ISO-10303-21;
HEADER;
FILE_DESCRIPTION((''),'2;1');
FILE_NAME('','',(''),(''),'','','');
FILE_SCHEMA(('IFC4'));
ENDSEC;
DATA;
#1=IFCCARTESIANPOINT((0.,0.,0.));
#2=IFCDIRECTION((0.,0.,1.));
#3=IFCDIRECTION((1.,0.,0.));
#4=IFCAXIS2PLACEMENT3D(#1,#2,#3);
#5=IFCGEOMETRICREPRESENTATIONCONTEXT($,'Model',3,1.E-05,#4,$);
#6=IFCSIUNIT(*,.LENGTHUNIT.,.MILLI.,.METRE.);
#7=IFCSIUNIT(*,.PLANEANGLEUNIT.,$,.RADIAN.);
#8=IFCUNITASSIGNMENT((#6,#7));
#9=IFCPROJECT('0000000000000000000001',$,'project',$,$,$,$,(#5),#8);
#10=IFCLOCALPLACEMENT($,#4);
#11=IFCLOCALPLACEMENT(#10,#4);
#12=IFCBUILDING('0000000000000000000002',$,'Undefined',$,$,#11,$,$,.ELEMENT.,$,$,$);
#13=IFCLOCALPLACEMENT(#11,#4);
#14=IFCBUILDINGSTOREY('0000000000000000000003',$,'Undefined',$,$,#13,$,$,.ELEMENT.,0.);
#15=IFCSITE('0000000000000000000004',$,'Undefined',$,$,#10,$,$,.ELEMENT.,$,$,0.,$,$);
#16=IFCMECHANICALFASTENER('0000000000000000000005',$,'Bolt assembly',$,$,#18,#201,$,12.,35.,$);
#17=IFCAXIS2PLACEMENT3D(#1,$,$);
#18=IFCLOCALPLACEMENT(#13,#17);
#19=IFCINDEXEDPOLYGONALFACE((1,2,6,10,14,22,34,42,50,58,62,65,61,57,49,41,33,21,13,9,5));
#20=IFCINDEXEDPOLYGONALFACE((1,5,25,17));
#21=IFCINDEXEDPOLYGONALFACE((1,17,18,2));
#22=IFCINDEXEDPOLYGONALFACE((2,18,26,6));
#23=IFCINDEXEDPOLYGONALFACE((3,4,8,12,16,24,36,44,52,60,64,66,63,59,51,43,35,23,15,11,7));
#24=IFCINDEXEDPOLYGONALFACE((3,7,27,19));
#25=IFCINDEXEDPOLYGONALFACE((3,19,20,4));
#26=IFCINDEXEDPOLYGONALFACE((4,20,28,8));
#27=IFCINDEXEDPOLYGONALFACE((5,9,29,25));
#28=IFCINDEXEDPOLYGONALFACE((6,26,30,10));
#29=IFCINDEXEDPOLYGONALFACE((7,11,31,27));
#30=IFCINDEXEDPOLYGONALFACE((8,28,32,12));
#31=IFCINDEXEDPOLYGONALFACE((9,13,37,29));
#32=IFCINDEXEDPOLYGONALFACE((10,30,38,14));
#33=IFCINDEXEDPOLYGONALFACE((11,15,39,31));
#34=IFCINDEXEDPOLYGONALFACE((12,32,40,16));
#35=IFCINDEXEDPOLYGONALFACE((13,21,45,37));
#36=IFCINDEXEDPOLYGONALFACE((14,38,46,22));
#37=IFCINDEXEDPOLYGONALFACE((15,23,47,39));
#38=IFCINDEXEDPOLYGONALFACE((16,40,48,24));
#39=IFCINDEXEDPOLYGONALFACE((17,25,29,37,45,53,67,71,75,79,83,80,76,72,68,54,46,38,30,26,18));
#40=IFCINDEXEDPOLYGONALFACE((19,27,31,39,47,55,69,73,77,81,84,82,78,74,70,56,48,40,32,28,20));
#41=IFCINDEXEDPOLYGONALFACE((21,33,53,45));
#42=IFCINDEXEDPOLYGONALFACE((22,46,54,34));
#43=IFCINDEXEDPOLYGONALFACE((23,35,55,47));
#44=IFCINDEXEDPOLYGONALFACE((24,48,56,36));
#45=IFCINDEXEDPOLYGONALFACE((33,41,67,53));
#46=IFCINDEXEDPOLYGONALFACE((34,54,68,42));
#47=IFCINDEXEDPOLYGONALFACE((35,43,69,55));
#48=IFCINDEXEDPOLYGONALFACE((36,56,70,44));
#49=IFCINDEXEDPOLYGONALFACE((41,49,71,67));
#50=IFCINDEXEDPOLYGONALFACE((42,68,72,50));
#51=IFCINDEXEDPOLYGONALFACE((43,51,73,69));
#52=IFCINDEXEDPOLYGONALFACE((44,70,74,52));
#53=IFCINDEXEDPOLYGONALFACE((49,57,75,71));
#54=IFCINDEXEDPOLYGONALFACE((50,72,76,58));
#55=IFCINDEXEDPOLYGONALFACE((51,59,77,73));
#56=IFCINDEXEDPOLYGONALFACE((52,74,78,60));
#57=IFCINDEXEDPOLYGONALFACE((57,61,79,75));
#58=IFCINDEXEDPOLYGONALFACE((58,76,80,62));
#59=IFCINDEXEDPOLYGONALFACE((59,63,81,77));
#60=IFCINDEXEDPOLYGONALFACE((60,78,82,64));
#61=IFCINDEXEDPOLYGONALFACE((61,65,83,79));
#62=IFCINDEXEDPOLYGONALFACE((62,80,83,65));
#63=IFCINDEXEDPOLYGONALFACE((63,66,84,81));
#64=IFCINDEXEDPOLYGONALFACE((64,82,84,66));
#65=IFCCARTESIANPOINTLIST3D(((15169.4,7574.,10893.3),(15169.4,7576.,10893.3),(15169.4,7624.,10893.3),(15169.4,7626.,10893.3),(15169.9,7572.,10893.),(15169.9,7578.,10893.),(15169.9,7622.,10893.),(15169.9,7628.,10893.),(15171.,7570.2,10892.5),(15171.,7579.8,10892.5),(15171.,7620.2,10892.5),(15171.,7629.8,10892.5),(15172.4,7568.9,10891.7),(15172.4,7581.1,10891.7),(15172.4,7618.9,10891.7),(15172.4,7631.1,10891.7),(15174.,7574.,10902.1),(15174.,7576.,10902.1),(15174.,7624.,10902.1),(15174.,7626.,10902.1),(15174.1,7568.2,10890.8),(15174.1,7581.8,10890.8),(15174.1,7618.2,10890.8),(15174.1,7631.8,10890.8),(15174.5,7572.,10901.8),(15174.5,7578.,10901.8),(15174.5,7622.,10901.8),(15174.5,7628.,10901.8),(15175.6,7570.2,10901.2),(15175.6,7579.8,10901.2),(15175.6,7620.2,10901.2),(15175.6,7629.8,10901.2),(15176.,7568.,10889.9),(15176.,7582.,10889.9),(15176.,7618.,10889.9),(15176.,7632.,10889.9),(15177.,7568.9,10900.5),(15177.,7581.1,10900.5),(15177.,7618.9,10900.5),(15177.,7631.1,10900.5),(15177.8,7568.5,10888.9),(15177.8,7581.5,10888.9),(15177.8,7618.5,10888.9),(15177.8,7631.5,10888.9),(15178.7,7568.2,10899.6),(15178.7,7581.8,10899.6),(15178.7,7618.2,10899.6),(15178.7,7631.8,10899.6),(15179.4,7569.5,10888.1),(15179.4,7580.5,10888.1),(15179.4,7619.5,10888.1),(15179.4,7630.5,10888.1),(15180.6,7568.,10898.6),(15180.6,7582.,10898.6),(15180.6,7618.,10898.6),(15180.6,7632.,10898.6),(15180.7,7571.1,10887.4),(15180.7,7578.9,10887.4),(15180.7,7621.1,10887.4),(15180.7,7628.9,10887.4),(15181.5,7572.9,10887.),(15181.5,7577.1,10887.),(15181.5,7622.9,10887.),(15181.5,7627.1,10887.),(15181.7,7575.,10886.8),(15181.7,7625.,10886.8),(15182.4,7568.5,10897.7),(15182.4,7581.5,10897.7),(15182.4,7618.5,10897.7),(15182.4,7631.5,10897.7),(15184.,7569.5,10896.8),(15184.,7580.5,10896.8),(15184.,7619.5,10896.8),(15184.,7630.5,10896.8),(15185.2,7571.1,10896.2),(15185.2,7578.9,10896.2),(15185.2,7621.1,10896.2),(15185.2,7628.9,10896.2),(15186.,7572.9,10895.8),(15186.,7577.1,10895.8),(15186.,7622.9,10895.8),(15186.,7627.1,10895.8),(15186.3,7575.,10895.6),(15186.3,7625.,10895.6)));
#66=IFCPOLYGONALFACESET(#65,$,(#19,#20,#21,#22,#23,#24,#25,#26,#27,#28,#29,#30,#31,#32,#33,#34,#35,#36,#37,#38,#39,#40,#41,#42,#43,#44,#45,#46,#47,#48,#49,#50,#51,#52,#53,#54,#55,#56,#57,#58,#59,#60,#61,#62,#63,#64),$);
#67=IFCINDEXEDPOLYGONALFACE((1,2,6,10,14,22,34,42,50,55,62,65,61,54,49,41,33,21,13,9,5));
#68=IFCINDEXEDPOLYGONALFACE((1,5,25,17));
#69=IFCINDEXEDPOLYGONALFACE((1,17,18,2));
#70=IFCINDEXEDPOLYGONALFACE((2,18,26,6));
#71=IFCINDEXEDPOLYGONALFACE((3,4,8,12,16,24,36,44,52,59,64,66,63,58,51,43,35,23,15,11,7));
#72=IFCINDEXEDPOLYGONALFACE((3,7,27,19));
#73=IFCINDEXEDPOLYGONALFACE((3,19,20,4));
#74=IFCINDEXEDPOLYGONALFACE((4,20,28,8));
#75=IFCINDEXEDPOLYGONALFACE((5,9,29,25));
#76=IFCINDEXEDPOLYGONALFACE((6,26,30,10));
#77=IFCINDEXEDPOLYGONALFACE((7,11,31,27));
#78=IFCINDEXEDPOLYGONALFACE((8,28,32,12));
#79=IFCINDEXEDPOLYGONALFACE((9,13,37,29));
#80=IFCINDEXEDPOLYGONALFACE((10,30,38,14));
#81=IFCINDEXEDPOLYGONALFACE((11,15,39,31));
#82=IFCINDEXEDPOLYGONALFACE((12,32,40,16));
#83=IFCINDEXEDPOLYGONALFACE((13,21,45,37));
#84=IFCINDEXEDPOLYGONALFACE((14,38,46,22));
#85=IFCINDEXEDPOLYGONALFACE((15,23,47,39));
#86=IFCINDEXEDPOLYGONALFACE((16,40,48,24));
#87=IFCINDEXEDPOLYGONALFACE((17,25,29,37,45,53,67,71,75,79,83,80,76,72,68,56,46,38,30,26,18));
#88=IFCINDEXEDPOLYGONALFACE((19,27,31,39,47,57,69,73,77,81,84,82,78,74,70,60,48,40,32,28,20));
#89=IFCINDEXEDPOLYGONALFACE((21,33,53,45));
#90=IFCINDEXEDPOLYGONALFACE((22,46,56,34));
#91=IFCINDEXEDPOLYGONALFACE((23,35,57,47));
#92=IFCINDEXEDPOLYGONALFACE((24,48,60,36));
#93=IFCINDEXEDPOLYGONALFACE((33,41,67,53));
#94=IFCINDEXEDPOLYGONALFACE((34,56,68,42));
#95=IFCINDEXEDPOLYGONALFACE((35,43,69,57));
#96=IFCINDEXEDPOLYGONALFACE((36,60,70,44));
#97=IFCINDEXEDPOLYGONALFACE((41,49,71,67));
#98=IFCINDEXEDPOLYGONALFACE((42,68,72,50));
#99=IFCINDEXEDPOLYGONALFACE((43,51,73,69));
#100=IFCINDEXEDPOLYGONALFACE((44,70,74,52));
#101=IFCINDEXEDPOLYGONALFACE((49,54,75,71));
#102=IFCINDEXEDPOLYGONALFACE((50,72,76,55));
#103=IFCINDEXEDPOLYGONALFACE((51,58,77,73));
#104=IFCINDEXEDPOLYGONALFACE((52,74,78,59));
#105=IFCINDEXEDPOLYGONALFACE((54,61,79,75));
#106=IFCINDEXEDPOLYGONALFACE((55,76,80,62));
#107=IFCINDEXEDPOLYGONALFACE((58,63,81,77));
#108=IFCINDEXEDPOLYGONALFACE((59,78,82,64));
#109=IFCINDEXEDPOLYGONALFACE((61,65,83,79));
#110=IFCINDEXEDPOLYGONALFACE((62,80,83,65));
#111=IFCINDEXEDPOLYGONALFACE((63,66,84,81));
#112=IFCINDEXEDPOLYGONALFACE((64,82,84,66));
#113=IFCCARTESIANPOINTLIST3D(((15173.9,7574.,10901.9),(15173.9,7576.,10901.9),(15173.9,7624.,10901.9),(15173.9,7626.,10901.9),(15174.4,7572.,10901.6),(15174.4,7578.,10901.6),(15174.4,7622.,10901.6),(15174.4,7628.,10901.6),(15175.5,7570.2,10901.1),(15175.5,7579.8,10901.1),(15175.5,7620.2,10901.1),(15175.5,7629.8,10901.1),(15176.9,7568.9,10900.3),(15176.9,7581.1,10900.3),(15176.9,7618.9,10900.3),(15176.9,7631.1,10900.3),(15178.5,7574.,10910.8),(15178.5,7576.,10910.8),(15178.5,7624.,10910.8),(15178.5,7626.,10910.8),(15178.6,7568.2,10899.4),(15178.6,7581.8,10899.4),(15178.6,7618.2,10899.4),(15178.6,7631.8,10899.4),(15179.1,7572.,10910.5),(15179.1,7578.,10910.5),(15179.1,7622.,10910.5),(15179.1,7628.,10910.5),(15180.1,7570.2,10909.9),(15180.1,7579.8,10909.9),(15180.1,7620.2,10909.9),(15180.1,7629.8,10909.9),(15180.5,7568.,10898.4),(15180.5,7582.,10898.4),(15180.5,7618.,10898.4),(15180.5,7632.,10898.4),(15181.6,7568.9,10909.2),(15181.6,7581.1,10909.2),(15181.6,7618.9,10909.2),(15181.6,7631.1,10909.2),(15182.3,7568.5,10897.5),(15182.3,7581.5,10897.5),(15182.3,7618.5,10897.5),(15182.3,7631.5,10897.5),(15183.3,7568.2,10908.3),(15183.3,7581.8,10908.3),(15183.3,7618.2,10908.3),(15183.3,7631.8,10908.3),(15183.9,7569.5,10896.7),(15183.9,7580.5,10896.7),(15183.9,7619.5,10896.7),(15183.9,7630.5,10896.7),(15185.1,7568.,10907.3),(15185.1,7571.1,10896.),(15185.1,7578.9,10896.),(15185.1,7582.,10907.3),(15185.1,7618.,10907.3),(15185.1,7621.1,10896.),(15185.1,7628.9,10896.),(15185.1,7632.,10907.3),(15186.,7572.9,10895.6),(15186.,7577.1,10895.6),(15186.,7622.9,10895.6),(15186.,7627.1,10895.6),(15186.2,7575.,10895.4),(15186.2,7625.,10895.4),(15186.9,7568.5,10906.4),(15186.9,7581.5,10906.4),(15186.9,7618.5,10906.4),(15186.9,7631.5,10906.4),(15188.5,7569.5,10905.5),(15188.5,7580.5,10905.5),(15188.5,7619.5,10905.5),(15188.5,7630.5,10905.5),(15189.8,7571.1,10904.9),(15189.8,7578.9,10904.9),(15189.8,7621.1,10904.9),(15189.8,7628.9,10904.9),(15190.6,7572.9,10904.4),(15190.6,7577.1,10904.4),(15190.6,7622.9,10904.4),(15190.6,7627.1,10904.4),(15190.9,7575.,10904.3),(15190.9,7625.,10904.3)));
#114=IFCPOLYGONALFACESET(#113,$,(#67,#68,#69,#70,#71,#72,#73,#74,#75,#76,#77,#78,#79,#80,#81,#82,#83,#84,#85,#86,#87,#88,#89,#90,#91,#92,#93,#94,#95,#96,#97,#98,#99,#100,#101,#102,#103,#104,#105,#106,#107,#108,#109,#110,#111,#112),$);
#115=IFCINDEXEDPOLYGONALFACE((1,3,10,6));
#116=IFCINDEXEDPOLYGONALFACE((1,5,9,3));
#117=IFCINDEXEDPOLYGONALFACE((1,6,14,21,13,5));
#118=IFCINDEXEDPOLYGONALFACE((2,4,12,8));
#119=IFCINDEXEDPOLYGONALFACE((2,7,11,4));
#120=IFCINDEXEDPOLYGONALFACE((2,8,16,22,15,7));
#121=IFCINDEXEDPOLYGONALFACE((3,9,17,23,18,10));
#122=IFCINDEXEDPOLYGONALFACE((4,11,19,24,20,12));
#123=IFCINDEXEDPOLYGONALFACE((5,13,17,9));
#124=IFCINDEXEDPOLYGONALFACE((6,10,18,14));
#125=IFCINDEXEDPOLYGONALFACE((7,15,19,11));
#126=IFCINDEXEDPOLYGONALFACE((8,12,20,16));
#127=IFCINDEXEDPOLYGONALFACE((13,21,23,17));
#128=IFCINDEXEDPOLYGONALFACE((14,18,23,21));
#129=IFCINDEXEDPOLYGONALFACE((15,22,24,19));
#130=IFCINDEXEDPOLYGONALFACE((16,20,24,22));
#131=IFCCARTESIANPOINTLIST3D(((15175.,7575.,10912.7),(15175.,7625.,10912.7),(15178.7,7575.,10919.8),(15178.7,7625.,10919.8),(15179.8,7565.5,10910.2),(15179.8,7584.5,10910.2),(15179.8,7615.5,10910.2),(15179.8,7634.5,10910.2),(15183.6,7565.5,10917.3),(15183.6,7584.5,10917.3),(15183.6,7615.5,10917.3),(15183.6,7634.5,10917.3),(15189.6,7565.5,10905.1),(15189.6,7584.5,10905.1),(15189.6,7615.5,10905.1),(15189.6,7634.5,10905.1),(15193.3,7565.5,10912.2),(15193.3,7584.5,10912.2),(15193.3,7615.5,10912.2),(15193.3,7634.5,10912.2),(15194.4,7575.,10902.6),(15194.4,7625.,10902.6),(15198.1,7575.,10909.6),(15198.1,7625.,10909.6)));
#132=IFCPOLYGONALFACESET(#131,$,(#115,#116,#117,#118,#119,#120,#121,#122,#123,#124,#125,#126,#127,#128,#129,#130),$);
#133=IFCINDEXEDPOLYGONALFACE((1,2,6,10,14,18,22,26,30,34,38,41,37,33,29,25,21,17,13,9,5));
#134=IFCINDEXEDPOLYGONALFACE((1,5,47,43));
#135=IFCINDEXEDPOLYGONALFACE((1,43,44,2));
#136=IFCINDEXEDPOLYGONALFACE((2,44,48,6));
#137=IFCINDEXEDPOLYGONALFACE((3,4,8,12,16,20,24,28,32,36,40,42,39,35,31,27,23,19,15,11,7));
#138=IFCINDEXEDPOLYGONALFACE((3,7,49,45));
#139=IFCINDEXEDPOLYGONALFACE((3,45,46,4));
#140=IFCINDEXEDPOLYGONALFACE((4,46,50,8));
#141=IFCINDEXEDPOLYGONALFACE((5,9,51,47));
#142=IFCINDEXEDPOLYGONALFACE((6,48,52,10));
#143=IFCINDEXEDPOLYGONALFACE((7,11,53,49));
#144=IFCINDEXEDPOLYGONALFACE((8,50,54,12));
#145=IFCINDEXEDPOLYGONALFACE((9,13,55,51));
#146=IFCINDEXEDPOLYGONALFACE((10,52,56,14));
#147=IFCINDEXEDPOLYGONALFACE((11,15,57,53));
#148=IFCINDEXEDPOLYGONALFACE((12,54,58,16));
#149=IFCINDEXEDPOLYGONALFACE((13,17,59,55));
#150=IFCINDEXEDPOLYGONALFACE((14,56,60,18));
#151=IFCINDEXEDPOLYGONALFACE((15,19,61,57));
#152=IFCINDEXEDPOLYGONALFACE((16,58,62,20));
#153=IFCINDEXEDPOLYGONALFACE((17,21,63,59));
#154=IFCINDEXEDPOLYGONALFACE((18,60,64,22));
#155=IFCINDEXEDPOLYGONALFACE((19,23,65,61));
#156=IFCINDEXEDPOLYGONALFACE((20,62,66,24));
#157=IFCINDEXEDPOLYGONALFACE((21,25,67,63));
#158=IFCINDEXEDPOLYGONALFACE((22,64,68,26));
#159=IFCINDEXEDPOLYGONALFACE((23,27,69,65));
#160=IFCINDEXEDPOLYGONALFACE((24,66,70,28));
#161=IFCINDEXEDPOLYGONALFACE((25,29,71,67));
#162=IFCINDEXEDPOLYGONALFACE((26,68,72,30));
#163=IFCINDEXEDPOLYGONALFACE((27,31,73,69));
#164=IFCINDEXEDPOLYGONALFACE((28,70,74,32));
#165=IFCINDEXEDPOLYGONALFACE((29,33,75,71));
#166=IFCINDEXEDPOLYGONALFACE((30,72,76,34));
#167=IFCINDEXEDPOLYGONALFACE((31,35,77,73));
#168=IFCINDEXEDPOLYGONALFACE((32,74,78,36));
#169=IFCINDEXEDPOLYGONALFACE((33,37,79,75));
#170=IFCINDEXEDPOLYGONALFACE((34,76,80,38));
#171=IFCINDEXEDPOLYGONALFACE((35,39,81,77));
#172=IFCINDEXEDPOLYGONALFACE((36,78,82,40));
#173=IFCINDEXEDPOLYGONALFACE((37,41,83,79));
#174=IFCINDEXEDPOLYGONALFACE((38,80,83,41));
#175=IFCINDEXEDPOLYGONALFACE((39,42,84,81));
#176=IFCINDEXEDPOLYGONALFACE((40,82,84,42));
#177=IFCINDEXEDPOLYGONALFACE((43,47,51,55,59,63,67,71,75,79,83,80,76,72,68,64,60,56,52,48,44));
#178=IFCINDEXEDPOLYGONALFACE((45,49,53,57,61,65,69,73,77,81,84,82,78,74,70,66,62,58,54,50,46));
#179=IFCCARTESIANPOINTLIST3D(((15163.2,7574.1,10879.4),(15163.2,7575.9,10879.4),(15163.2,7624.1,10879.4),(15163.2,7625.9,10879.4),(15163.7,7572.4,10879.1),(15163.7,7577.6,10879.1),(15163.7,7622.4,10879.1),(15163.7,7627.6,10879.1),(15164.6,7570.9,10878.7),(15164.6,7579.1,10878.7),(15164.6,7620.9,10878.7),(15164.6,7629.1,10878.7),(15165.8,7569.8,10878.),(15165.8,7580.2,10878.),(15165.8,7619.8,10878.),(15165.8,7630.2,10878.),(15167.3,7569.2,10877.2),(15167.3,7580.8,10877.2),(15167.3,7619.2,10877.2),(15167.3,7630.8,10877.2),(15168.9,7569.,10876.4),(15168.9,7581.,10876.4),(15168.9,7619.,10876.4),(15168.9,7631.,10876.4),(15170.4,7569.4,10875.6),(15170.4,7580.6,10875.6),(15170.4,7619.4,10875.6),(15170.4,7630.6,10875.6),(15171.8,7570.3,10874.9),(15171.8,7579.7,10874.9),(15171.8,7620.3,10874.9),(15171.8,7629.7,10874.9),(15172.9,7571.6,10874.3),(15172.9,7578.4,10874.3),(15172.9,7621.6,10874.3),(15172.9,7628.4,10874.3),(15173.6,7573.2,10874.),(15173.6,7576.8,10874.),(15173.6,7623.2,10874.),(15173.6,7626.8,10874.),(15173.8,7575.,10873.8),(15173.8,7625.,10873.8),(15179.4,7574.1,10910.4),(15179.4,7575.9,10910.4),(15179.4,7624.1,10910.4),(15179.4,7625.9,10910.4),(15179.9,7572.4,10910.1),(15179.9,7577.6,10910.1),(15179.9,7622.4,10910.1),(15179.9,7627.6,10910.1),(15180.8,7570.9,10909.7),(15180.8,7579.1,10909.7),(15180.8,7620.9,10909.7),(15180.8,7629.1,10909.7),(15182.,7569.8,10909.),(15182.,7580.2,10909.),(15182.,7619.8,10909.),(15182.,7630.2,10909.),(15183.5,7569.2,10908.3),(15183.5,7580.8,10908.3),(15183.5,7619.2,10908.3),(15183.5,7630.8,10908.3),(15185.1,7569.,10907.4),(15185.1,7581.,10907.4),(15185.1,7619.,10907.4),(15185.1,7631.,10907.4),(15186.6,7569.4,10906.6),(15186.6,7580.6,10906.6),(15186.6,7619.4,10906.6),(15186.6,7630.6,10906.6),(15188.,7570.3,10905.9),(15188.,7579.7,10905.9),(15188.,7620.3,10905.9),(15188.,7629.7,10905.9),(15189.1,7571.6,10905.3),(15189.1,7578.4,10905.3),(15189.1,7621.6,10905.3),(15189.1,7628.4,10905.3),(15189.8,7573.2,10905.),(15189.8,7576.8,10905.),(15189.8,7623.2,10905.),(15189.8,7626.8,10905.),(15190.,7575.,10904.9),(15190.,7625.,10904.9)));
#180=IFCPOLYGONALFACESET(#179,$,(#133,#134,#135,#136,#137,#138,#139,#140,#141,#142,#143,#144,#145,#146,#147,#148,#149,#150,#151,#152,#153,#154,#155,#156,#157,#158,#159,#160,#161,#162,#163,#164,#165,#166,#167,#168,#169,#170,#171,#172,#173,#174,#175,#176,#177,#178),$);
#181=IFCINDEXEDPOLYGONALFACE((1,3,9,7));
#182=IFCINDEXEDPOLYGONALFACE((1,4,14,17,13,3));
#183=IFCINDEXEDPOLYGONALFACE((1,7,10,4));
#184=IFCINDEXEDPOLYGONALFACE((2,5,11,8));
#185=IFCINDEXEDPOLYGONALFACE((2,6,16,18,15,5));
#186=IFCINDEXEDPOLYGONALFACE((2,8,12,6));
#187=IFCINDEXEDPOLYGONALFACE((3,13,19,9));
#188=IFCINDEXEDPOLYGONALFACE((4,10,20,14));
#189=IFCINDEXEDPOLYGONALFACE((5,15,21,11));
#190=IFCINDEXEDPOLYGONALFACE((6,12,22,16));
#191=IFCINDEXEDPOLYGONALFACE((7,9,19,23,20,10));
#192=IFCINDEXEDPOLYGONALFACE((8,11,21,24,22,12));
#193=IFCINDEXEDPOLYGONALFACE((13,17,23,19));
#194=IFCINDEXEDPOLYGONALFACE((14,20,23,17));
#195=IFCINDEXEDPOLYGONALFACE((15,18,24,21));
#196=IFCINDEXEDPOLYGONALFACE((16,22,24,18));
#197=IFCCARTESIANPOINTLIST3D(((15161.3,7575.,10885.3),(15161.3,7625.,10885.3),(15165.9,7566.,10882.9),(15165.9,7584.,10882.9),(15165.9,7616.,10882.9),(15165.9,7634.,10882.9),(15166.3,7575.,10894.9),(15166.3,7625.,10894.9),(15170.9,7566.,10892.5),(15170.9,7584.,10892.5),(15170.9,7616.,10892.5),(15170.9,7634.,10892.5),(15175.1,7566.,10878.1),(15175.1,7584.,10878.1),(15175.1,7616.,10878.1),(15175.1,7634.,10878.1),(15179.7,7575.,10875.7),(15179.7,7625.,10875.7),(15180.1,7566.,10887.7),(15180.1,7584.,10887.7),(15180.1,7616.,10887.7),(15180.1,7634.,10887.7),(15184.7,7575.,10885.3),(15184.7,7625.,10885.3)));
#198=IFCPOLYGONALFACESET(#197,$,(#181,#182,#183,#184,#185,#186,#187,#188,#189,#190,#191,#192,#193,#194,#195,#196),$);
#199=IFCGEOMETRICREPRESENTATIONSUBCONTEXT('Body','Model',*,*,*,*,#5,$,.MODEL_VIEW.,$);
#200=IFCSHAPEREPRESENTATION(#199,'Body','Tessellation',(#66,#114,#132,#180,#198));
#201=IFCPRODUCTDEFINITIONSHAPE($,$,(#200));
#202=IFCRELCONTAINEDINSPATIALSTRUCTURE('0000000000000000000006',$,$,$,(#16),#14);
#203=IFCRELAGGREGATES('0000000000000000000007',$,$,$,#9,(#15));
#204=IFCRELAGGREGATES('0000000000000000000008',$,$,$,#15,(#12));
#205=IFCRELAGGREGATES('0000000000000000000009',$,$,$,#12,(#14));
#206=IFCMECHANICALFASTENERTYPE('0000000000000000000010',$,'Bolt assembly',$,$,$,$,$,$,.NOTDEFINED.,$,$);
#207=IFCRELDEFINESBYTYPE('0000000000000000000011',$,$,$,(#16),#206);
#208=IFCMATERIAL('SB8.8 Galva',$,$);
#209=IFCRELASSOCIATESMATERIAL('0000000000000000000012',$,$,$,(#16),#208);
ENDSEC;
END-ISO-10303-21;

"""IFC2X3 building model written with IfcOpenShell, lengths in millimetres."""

from ifc_helpers import new_model, si_unit, frame, origin_with_axes, origin_2d_with_axis, place, context, subcontext, project, spatial, polyline, circle, outline, extrude, source, transform, mapped, material, type_object, element, save


model = new_model("IFC2X3")

# Units and contexts
model_context = context("Model", 3, precision=1e-05, world=origin_with_axes())
body_context = subcontext(model_context, "Body", "Model", "MODEL_VIEW")
ifc_project = project(units=[si_unit("LENGTHUNIT", "METRE", prefix="MILLI"), si_unit("PLANEANGLEUNIT", "RADIAN")], contexts=[model_context])

# Site, building, storey
site_placement = place(None, origin_with_axes())
site = spatial("IfcSite", under=ifc_project, at=site_placement, Name="Undefined", CompositionType="ELEMENT", RefElevation=0.0)
building_placement = place(site_placement, origin_with_axes())
building = spatial("IfcBuilding", under=site, at=building_placement, Name="Undefined", CompositionType="ELEMENT")
storey_placement = place(building_placement, origin_with_axes())
storey = spatial("IfcBuildingStorey", under=building, at=storey_placement, Name="Undefined", CompositionType="ELEMENT", Elevation=0.0)

# Mechanical fastener
ifc_material_1 = material(Name="SB8.8 Galva")
mechanical_fastener_type = type_object("IfcMechanicalFastenerType", Name="Bolt assembly")
shared_shape_1 = source(origin_with_axes(), body_context, "Body", "SweptSolid", [
    extrude(circle(Radius=7.0, at=origin_2d_with_axis()), frame((0.0, -0.1, 0.0), z_axis=(0.0, 1.0, 0.0), x_axis=(1.0, 0.0, 0.0)), (0.0, 0.0, 1.0), 9.9),
    extrude(circle(Radius=7.0, at=origin_2d_with_axis()), frame((0.0, -9.9, 0.0), z_axis=(0.0, 1.0, 0.0), x_axis=(1.0, 0.0, 0.0)), (0.0, 0.0, 1.0), 10.0),
    extrude(outline(polyline([(11.0, 0.0), (5.5, 9.5), (-5.5, 9.5), (-11.0, 0.0), (-5.5, -9.5), (5.5, -9.5), (11.0, 0.0)])), frame((0.0, -18.0, 0.0), z_axis=(0.0, 1.0, 0.0), x_axis=(1.0, 0.0, 0.0)), (0.0, 0.0, 1.0), 8.0),
    extrude(circle(Radius=6.0, at=origin_2d_with_axis()), frame((0.0, -10.0, 0.0), z_axis=(0.0, 1.0, 0.0), x_axis=(1.0, 0.0, 0.0)), (0.0, 0.0, 1.0), 35.0),
    extrude(outline(polyline([(10.4, 0.0), (5.2, 9.0), (-5.2, 9.0), (-10.4, 0.0), (-5.2, -9.0), (5.2, -9.0), (10.4, 0.0)])), frame((0.0, 9.8, 0.0), z_axis=(0.0, 1.0, 0.0), x_axis=(1.0, 0.0, 0.0)), (0.0, 0.0, 1.0), 10.8),
])
for number, where, z_axis, x_axis, name in (
    (1, (15180.1, 7600.0, 10898.8), (0.0, 1.0, 0.0), (0.886082, 0.0, -0.463529), "Bolt assembly"),
):
    element("IfcMechanicalFastener", number, at=place(storey_placement, frame(where, z_axis=z_axis, x_axis=x_axis)), inside=storey, type_object=mechanical_fastener_type, material=ifc_material_1, Name=name, NominalDiameter=12.0, NominalLength=35.0, context=body_context, shape_type="MappedRepresentation", body=[
        mapped(shared_shape_1, transform((0.0, 0.0, -25.0))),
        mapped(shared_shape_1, transform((0.0, 0.0, 25.0))),
    ])

save(model, "model.ifc")
